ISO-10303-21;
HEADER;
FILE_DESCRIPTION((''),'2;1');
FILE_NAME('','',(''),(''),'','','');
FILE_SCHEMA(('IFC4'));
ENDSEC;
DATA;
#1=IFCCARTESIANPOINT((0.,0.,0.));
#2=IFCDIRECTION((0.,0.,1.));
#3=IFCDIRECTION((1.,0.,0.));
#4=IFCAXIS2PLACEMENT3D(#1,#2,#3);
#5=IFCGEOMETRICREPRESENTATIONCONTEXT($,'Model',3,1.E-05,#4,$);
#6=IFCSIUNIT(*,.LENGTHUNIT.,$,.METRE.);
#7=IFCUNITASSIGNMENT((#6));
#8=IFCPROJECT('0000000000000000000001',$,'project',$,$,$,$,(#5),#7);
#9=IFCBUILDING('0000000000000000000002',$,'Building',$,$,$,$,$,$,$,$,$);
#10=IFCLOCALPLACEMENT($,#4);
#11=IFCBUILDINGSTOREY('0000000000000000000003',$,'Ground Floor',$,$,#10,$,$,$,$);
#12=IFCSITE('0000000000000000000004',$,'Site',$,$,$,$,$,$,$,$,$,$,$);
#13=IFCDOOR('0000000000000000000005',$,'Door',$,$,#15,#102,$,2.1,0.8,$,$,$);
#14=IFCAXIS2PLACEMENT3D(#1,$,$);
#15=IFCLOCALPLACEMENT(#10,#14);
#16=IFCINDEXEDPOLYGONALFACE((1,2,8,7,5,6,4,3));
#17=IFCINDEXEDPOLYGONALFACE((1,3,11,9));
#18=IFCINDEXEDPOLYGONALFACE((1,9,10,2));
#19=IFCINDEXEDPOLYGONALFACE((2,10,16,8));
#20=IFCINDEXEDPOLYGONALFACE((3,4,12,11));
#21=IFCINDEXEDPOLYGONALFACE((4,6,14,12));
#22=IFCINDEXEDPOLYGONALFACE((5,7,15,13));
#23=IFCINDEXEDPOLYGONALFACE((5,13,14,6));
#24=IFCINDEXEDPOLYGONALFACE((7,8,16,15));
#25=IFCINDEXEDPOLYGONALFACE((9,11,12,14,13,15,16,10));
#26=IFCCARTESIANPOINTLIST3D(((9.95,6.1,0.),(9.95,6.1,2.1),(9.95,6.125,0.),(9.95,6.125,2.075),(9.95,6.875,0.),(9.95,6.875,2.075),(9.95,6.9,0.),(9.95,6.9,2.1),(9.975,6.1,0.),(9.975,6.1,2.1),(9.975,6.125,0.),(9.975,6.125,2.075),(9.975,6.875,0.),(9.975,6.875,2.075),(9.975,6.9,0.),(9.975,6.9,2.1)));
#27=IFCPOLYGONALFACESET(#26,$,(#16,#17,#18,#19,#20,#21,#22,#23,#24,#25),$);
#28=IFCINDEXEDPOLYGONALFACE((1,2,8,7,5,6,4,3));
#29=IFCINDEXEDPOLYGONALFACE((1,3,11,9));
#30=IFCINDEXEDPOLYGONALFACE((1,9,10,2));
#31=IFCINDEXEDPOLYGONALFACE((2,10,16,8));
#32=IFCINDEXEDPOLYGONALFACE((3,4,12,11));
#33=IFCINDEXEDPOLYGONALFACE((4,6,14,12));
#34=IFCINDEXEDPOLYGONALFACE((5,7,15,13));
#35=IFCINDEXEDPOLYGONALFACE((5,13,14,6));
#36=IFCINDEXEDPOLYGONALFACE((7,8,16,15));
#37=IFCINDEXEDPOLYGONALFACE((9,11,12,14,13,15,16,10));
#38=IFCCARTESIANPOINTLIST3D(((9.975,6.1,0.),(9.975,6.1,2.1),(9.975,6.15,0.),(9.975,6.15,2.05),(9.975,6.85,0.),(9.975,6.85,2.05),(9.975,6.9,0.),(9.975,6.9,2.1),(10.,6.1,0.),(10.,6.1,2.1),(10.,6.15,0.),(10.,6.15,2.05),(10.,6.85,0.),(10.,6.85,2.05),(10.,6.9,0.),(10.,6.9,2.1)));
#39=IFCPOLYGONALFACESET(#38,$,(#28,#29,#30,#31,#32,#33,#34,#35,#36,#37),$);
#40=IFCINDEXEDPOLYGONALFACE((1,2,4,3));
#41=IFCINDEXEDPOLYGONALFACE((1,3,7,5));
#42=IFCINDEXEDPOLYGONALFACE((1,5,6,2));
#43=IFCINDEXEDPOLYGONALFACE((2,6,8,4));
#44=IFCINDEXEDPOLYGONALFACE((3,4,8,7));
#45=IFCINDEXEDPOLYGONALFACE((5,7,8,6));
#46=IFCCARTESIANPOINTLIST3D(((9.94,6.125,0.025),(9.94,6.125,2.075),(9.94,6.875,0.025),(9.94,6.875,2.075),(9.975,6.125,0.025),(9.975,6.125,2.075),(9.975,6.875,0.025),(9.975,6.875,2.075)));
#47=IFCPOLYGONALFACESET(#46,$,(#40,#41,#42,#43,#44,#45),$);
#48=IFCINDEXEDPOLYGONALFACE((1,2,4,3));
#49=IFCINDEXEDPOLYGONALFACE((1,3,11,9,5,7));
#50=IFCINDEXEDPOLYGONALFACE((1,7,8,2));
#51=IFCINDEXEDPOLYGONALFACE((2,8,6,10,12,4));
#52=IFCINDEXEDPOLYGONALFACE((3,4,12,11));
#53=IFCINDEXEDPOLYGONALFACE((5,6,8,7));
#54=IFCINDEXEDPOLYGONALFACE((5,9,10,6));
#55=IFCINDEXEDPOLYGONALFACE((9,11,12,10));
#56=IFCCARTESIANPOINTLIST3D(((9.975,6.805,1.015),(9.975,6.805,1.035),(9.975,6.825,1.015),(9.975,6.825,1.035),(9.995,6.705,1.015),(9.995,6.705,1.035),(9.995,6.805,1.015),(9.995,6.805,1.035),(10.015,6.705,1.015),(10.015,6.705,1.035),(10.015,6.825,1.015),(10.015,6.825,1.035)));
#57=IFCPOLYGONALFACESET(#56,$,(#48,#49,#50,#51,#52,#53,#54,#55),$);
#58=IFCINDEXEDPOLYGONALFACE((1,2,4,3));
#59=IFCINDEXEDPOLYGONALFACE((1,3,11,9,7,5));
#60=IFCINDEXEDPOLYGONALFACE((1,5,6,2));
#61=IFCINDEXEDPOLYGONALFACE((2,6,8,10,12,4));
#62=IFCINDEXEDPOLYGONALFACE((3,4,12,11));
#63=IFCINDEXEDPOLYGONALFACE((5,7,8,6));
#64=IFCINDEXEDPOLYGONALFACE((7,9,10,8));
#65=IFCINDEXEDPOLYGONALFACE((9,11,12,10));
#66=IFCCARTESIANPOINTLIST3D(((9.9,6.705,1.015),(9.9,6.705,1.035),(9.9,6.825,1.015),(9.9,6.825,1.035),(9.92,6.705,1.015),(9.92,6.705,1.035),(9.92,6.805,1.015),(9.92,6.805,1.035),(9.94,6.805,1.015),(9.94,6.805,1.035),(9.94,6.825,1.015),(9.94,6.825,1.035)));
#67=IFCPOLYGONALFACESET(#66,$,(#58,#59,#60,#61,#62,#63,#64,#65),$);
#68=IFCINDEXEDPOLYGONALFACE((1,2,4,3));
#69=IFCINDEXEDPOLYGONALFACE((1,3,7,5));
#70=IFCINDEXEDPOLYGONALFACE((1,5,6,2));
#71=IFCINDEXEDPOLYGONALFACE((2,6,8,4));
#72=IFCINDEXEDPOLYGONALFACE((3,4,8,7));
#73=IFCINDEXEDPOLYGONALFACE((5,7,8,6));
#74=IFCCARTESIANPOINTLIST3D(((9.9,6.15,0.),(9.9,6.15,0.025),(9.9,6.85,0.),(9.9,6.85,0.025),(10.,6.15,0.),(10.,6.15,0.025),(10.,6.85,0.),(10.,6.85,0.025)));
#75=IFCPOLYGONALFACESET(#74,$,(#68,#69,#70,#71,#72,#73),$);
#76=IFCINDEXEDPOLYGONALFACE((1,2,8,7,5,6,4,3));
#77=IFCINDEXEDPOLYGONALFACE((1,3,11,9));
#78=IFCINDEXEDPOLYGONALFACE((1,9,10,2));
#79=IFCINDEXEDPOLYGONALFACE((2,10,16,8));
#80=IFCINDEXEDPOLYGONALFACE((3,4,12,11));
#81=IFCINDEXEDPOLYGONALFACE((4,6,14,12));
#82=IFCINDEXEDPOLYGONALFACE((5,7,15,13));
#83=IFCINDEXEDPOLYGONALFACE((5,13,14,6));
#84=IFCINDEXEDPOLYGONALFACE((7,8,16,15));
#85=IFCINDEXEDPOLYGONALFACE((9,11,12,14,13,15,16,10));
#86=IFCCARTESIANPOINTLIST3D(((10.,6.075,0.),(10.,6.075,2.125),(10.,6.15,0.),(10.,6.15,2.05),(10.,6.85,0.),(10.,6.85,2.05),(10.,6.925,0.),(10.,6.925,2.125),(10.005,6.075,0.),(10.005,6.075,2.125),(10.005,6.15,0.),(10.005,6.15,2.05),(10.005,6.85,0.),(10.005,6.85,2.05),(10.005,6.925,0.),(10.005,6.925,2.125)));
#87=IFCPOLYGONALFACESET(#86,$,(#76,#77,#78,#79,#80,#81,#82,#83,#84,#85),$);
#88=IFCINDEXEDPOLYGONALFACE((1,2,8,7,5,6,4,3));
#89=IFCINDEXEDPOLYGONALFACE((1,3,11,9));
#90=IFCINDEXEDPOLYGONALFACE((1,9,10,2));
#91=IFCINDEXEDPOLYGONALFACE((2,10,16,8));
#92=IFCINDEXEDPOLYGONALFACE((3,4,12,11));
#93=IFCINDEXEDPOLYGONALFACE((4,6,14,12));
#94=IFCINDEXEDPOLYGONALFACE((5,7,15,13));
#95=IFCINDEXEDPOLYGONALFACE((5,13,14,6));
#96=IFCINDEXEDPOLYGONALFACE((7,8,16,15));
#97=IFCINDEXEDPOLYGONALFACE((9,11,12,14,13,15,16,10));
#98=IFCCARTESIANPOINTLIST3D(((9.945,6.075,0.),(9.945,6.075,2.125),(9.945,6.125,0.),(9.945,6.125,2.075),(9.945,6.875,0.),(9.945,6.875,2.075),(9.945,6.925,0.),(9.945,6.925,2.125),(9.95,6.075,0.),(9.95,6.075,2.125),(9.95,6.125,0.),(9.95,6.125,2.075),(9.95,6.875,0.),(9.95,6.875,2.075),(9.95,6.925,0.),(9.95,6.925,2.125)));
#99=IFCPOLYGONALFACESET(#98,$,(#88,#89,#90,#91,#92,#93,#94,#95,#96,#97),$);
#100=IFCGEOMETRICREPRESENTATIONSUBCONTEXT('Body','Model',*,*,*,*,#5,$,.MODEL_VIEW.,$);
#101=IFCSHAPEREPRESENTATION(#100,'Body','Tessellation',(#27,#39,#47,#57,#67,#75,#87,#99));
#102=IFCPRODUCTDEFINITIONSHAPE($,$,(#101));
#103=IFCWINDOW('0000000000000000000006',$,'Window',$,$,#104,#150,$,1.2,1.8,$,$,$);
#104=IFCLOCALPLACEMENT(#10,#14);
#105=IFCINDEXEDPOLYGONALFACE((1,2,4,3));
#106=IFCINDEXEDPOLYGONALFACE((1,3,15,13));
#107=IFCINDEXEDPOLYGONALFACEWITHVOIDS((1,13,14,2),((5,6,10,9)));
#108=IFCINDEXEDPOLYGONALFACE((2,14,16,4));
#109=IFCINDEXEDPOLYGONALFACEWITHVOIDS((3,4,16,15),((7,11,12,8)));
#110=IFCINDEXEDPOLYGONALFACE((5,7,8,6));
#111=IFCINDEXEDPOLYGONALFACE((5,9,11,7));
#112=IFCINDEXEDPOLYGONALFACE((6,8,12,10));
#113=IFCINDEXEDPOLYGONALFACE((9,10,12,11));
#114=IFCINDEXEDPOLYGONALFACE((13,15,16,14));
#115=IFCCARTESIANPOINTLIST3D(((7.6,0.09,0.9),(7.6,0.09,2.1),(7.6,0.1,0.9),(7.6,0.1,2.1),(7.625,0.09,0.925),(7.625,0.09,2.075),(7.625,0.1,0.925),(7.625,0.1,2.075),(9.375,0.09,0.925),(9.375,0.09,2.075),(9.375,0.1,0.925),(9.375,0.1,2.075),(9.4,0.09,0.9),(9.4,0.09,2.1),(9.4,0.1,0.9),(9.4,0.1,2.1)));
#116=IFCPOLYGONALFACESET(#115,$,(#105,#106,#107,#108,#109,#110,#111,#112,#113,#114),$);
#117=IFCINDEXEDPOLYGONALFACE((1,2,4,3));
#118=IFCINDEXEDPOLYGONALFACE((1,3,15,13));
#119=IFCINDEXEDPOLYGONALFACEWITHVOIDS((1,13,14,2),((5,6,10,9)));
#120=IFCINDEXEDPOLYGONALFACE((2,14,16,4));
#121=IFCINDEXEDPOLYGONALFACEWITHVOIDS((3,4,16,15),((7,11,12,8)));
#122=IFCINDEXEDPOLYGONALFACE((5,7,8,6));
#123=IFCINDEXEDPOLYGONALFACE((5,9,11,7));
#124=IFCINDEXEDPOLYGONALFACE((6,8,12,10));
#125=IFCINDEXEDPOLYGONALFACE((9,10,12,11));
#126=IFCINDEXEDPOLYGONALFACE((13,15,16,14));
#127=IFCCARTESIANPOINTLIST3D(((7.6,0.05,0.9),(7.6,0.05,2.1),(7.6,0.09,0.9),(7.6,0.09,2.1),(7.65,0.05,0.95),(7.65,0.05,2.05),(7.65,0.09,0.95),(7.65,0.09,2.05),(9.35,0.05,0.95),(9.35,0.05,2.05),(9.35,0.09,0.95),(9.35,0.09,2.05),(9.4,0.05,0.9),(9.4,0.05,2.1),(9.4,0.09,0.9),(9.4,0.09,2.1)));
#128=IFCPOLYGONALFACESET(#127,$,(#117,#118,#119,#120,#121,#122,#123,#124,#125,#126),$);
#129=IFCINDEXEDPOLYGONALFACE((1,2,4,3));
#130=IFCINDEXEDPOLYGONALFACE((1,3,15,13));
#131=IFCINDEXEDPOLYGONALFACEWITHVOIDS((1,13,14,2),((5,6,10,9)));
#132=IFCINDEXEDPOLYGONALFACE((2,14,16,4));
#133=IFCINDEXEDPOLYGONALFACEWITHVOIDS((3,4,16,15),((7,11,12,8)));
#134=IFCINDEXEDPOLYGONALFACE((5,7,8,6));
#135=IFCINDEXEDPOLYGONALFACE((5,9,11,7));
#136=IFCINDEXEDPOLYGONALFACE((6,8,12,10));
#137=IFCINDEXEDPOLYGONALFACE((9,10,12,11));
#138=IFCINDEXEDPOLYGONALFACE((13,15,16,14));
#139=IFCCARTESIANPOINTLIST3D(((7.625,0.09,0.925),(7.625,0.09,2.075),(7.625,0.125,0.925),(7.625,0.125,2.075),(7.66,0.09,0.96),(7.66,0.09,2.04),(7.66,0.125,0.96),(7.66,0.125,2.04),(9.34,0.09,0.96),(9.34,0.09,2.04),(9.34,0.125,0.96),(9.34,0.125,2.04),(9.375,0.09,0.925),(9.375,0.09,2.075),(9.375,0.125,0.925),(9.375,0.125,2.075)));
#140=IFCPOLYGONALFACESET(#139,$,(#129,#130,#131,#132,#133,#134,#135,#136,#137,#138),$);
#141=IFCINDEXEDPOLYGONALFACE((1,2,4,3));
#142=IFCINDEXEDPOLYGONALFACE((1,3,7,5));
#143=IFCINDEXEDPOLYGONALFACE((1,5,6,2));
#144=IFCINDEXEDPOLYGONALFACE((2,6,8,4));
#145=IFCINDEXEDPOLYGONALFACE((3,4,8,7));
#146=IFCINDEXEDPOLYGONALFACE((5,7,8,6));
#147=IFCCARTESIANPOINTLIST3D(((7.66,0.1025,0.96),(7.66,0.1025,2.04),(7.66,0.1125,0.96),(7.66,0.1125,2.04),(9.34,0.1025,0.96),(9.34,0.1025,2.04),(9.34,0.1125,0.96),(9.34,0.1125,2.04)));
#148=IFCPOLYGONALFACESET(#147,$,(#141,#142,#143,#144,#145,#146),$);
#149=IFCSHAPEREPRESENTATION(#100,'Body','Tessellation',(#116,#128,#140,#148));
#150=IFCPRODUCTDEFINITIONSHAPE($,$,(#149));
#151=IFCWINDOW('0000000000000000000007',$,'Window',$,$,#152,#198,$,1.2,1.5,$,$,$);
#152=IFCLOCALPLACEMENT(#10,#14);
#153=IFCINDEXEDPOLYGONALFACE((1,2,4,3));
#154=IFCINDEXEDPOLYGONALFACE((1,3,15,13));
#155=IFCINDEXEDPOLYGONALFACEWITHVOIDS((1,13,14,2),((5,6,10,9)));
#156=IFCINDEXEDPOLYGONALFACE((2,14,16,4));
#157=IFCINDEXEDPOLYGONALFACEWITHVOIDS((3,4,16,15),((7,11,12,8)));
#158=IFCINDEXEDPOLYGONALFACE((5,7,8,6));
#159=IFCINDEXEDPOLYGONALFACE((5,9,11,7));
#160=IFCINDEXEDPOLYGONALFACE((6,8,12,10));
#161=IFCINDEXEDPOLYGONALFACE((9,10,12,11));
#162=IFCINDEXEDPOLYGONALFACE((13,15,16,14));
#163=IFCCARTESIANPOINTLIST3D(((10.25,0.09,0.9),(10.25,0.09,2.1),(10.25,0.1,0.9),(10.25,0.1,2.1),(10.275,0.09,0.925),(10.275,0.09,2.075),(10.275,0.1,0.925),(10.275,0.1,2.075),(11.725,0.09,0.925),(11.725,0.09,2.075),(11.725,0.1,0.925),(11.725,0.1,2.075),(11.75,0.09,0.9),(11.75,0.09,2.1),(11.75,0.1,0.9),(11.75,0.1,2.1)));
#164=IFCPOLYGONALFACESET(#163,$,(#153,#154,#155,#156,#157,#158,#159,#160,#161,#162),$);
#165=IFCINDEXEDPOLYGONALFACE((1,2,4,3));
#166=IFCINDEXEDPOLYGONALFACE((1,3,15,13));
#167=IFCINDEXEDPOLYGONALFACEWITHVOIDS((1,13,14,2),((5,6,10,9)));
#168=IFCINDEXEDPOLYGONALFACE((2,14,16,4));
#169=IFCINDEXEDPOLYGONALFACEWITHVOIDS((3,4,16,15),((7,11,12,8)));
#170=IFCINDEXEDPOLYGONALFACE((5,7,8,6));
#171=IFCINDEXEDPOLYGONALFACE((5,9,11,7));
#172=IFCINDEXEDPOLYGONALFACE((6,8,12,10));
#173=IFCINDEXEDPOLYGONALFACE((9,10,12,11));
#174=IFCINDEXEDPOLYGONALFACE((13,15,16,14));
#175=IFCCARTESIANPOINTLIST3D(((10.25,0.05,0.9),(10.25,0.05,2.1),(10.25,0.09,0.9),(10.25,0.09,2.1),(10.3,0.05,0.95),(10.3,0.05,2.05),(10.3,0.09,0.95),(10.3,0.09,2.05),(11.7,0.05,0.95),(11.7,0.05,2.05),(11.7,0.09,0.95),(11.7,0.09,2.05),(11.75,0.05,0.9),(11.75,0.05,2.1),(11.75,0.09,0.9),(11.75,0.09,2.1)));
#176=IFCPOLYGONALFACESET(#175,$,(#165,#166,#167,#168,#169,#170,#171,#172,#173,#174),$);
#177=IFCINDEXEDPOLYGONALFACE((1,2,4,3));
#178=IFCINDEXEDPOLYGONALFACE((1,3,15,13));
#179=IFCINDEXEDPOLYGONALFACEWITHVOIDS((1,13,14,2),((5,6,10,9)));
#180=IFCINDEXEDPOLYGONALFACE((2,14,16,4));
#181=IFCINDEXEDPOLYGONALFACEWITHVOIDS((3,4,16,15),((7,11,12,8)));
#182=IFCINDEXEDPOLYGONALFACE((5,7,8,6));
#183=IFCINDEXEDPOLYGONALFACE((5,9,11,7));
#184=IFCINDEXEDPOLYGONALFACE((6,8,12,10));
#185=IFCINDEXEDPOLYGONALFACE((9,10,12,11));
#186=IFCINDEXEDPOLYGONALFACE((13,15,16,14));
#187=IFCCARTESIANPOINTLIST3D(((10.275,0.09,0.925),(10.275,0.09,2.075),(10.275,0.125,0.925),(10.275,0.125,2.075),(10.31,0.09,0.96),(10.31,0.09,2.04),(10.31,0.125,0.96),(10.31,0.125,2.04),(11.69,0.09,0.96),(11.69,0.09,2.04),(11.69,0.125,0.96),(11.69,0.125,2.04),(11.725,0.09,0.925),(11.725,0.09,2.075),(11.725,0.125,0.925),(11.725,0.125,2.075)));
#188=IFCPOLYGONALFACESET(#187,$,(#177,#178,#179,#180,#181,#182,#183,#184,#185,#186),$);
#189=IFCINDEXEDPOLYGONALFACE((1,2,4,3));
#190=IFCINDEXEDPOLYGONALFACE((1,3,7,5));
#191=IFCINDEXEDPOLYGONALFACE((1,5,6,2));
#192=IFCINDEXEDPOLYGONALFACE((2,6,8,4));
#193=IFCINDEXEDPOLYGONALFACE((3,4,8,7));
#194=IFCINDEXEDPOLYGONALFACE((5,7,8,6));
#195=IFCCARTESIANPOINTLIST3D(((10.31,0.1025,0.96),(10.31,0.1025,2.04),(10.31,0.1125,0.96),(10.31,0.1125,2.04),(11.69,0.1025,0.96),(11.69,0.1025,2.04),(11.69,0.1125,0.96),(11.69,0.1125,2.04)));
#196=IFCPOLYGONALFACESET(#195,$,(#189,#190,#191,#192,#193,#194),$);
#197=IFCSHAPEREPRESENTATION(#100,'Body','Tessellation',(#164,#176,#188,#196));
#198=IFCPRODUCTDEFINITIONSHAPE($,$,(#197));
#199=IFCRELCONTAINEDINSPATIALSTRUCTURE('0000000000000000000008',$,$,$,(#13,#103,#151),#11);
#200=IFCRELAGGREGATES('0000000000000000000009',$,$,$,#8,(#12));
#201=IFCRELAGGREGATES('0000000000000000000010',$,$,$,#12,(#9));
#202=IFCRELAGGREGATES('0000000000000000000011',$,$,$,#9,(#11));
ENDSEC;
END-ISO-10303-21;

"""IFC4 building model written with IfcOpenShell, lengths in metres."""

from ifc_helpers import new_model, si_unit, frame, origin_with_axes, place, context, subcontext, project, spatial, line, indexed_curve, outline, extrude, element, save


model = new_model("IFC4")

# Units and contexts
model_context = context("Model", 3, precision=1e-05, world=origin_with_axes())
body_context = subcontext(model_context, "Body", "Model", "MODEL_VIEW")
ifc_project = project(units=[si_unit("LENGTHUNIT", "METRE")], contexts=[model_context])

# Site, building, storey
site = spatial("IfcSite", under=ifc_project, Name="Site")
building = spatial("IfcBuilding", under=site, Name="Building")
storey_placement = place(None, origin_with_axes())
storey = spatial("IfcBuildingStorey", under=building, at=storey_placement, Name="Ground Floor")

# Door
door_1_placement = place(storey_placement, frame((10.0, 6.1, 0.0), z_axis=(0.0, 0.0, 1.0), x_axis=(0.0, 1.0, 0.0)))
element("IfcDoor", 1, at=door_1_placement, inside=storey, Name="Door", OverallHeight=2.1, OverallWidth=0.8, context=body_context, shape_type="SweptSolid", body=[
    extrude(outline(indexed_curve([(0.0, 0.0), (0.0, 2.1), (0.8, 2.1), (0.8, 0.0), (0.775, 0.0), (0.775, 2.075), (0.025, 2.075), (0.025, 0.0)], segments=[line(1, 2, 3, 4, 5, 6, 7, 8, 1)])), frame((0.0, 0.025, 0.0), z_axis=(0.0, -1.0, 0.0), x_axis=(1.0, 0.0, 0.0)), (0.0, 0.0, -1.0), 0.025),
    extrude(outline(indexed_curve([(0.0, 0.0), (0.0, 2.1), (0.8, 2.1), (0.8, 0.0), (0.75, 0.0), (0.75, 2.05), (0.05, 2.05), (0.05, 0.0)], segments=[line(1, 2, 3, 4, 5, 6, 7, 8, 1)])), frame((0.0, 0.0, 0.0), z_axis=(0.0, -1.0, 0.0), x_axis=(1.0, 0.0, 0.0)), (0.0, 0.0, -1.0), 0.025),
    extrude(outline(indexed_curve([(0.0, 0.0), (0.75, 0.0), (0.75, 0.035), (0.0, 0.035)], segments=[line(1, 2, 3, 4, 1)])), frame((0.025, 0.025, 0.025), z_axis=(0.0, 0.0, 1.0), x_axis=(1.0, 0.0, 0.0)), (0.0, 0.0, 1.0), 2.05),
    extrude(outline(indexed_curve([(0.0, 0.0), (0.0, -0.04), (-0.12, -0.04), (-0.12, -0.02), (-0.02, -0.02), (-0.02, 0.0)], segments=[line(1, 2, 3, 4, 5, 6, 1)])), frame((0.725, 0.025, 1.015), z_axis=(0.0, 0.0, 1.0), x_axis=(1.0, 0.0, 0.0)), (0.0, 0.0, 1.0), 0.02),
    extrude(outline(indexed_curve([(0.0, 0.0), (0.0, 0.04), (-0.12, 0.04), (-0.12, 0.02), (-0.02, 0.02), (-0.02, 0.0)], segments=[line(1, 2, 3, 4, 5, 6, 1)])), frame((0.725, 0.06, 1.015), z_axis=(0.0, 0.0, 1.0), x_axis=(1.0, 0.0, 0.0)), (0.0, 0.0, 1.0), 0.02),
    extrude(outline(indexed_curve([(0.0, 0.0), (0.7, 0.0), (0.7, 0.1), (0.0, 0.1)], segments=[line(1, 2, 3, 4, 1)])), frame((0.05, 0.0, 0.0), z_axis=(0.0, 0.0, 1.0), x_axis=(1.0, 0.0, 0.0)), (0.0, 0.0, 1.0), 0.025),
    extrude(outline(indexed_curve([(0.0, 0.0), (0.0, 2.125), (0.85, 2.125), (0.85, 0.0), (0.775, 0.0), (0.775, 2.05), (0.075, 2.05), (0.075, 0.0)], segments=[line(1, 2, 3, 4, 5, 6, 7, 8, 1)])), frame((-0.025, -0.005, 0.0), z_axis=(0.0, -1.0, 0.0), x_axis=(1.0, 0.0, 0.0)), (0.0, 0.0, -1.0), 0.005),
    extrude(outline(indexed_curve([(0.0, 0.0), (0.0, 2.125), (0.85, 2.125), (0.85, 0.0), (0.8, 0.0), (0.8, 2.075), (0.05, 2.075), (0.05, 0.0)], segments=[line(1, 2, 3, 4, 5, 6, 7, 8, 1)])), frame((-0.025, 0.05, 0.0), z_axis=(0.0, -1.0, 0.0), x_axis=(1.0, 0.0, 0.0)), (0.0, 0.0, -1.0), 0.005),
])

# Windows
window_1_placement = place(storey_placement, frame((7.6, 0.0, 0.9), z_axis=(0.0, 0.0, 1.0), x_axis=(1.0, 0.0, 0.0)))
element("IfcWindow", 2, at=window_1_placement, inside=storey, Name="Window", OverallHeight=1.2, OverallWidth=1.8, context=body_context, shape_type="SweptSolid", body=[
    extrude(outline(indexed_curve([(0.0, 0.0), (1.8, 0.0), (1.8, 1.2), (0.0, 1.2)], segments=[line(1, 2, 3, 4, 1)]), holes=[indexed_curve([(0.025, 0.025), (1.775, 0.025), (1.775, 1.175), (0.025, 1.175)], segments=[line(1, 2, 3, 4, 1)])]), frame((0.0, 0.09, 0.0), z_axis=(0.0, -1.0, 0.0), x_axis=(1.0, 0.0, 0.0)), (0.0, 0.0, -1.0), 0.01),
    extrude(outline(indexed_curve([(0.0, 0.0), (1.8, 0.0), (1.8, 1.2), (0.0, 1.2)], segments=[line(1, 2, 3, 4, 1)]), holes=[indexed_curve([(0.05, 0.05), (1.75, 0.05), (1.75, 1.15), (0.05, 1.15)], segments=[line(1, 2, 3, 4, 1)])]), frame((0.0, 0.05, 0.0), z_axis=(0.0, -1.0, 0.0), x_axis=(1.0, 0.0, 0.0)), (0.0, 0.0, -1.0), 0.04),
    extrude(outline(indexed_curve([(0.0, 0.0), (1.75, 0.0), (1.75, 1.15), (0.0, 1.15)], segments=[line(1, 2, 3, 4, 1)]), holes=[indexed_curve([(0.035, 0.035), (1.715, 0.035), (1.715, 1.115), (0.035, 1.115)], segments=[line(1, 2, 3, 4, 1)])]), frame((0.025, 0.09, 0.025), z_axis=(0.0, -1.0, 0.0), x_axis=(1.0, 0.0, 0.0)), (0.0, 0.0, -1.0), 0.035),
    extrude(outline(indexed_curve([(0.035, 0.035), (1.715, 0.035), (1.715, 1.115), (0.035, 1.115)], segments=[line(1, 2, 3, 4, 1)])), frame((0.025, 0.1025, 0.025), z_axis=(0.0, -1.0, 0.0), x_axis=(1.0, 0.0, 0.0)), (0.0, 0.0, -1.0), 0.01),
])
window_2_placement = place(storey_placement, frame((10.25, 0.0, 0.9), z_axis=(0.0, 0.0, 1.0), x_axis=(1.0, 0.0, 0.0)))
element("IfcWindow", 3, at=window_2_placement, inside=storey, Name="Window", OverallHeight=1.2, OverallWidth=1.5, context=body_context, shape_type="SweptSolid", body=[
    extrude(outline(indexed_curve([(0.0, 0.0), (1.5, 0.0), (1.5, 1.2), (0.0, 1.2)], segments=[line(1, 2, 3, 4, 1)]), holes=[indexed_curve([(0.025, 0.025), (1.475, 0.025), (1.475, 1.175), (0.025, 1.175)], segments=[line(1, 2, 3, 4, 1)])]), frame((0.0, 0.09, 0.0), z_axis=(0.0, -1.0, 0.0), x_axis=(1.0, 0.0, 0.0)), (0.0, 0.0, -1.0), 0.01),
    extrude(outline(indexed_curve([(0.0, 0.0), (1.5, 0.0), (1.5, 1.2), (0.0, 1.2)], segments=[line(1, 2, 3, 4, 1)]), holes=[indexed_curve([(0.05, 0.05), (1.45, 0.05), (1.45, 1.15), (0.05, 1.15)], segments=[line(1, 2, 3, 4, 1)])]), frame((0.0, 0.05, 0.0), z_axis=(0.0, -1.0, 0.0), x_axis=(1.0, 0.0, 0.0)), (0.0, 0.0, -1.0), 0.04),
    extrude(outline(indexed_curve([(0.0, 0.0), (1.45, 0.0), (1.45, 1.15), (0.0, 1.15)], segments=[line(1, 2, 3, 4, 1)]), holes=[indexed_curve([(0.035, 0.035), (1.415, 0.035), (1.415, 1.115), (0.035, 1.115)], segments=[line(1, 2, 3, 4, 1)])]), frame((0.025, 0.09, 0.025), z_axis=(0.0, -1.0, 0.0), x_axis=(1.0, 0.0, 0.0)), (0.0, 0.0, -1.0), 0.035),
    extrude(outline(indexed_curve([(0.035, 0.035), (1.415, 0.035), (1.415, 1.115), (0.035, 1.115)], segments=[line(1, 2, 3, 4, 1)])), frame((0.025, 0.1025, 0.025), z_axis=(0.0, -1.0, 0.0), x_axis=(1.0, 0.0, 0.0)), (0.0, 0.0, -1.0), 0.01),
])

save(model, "model.ifc")
